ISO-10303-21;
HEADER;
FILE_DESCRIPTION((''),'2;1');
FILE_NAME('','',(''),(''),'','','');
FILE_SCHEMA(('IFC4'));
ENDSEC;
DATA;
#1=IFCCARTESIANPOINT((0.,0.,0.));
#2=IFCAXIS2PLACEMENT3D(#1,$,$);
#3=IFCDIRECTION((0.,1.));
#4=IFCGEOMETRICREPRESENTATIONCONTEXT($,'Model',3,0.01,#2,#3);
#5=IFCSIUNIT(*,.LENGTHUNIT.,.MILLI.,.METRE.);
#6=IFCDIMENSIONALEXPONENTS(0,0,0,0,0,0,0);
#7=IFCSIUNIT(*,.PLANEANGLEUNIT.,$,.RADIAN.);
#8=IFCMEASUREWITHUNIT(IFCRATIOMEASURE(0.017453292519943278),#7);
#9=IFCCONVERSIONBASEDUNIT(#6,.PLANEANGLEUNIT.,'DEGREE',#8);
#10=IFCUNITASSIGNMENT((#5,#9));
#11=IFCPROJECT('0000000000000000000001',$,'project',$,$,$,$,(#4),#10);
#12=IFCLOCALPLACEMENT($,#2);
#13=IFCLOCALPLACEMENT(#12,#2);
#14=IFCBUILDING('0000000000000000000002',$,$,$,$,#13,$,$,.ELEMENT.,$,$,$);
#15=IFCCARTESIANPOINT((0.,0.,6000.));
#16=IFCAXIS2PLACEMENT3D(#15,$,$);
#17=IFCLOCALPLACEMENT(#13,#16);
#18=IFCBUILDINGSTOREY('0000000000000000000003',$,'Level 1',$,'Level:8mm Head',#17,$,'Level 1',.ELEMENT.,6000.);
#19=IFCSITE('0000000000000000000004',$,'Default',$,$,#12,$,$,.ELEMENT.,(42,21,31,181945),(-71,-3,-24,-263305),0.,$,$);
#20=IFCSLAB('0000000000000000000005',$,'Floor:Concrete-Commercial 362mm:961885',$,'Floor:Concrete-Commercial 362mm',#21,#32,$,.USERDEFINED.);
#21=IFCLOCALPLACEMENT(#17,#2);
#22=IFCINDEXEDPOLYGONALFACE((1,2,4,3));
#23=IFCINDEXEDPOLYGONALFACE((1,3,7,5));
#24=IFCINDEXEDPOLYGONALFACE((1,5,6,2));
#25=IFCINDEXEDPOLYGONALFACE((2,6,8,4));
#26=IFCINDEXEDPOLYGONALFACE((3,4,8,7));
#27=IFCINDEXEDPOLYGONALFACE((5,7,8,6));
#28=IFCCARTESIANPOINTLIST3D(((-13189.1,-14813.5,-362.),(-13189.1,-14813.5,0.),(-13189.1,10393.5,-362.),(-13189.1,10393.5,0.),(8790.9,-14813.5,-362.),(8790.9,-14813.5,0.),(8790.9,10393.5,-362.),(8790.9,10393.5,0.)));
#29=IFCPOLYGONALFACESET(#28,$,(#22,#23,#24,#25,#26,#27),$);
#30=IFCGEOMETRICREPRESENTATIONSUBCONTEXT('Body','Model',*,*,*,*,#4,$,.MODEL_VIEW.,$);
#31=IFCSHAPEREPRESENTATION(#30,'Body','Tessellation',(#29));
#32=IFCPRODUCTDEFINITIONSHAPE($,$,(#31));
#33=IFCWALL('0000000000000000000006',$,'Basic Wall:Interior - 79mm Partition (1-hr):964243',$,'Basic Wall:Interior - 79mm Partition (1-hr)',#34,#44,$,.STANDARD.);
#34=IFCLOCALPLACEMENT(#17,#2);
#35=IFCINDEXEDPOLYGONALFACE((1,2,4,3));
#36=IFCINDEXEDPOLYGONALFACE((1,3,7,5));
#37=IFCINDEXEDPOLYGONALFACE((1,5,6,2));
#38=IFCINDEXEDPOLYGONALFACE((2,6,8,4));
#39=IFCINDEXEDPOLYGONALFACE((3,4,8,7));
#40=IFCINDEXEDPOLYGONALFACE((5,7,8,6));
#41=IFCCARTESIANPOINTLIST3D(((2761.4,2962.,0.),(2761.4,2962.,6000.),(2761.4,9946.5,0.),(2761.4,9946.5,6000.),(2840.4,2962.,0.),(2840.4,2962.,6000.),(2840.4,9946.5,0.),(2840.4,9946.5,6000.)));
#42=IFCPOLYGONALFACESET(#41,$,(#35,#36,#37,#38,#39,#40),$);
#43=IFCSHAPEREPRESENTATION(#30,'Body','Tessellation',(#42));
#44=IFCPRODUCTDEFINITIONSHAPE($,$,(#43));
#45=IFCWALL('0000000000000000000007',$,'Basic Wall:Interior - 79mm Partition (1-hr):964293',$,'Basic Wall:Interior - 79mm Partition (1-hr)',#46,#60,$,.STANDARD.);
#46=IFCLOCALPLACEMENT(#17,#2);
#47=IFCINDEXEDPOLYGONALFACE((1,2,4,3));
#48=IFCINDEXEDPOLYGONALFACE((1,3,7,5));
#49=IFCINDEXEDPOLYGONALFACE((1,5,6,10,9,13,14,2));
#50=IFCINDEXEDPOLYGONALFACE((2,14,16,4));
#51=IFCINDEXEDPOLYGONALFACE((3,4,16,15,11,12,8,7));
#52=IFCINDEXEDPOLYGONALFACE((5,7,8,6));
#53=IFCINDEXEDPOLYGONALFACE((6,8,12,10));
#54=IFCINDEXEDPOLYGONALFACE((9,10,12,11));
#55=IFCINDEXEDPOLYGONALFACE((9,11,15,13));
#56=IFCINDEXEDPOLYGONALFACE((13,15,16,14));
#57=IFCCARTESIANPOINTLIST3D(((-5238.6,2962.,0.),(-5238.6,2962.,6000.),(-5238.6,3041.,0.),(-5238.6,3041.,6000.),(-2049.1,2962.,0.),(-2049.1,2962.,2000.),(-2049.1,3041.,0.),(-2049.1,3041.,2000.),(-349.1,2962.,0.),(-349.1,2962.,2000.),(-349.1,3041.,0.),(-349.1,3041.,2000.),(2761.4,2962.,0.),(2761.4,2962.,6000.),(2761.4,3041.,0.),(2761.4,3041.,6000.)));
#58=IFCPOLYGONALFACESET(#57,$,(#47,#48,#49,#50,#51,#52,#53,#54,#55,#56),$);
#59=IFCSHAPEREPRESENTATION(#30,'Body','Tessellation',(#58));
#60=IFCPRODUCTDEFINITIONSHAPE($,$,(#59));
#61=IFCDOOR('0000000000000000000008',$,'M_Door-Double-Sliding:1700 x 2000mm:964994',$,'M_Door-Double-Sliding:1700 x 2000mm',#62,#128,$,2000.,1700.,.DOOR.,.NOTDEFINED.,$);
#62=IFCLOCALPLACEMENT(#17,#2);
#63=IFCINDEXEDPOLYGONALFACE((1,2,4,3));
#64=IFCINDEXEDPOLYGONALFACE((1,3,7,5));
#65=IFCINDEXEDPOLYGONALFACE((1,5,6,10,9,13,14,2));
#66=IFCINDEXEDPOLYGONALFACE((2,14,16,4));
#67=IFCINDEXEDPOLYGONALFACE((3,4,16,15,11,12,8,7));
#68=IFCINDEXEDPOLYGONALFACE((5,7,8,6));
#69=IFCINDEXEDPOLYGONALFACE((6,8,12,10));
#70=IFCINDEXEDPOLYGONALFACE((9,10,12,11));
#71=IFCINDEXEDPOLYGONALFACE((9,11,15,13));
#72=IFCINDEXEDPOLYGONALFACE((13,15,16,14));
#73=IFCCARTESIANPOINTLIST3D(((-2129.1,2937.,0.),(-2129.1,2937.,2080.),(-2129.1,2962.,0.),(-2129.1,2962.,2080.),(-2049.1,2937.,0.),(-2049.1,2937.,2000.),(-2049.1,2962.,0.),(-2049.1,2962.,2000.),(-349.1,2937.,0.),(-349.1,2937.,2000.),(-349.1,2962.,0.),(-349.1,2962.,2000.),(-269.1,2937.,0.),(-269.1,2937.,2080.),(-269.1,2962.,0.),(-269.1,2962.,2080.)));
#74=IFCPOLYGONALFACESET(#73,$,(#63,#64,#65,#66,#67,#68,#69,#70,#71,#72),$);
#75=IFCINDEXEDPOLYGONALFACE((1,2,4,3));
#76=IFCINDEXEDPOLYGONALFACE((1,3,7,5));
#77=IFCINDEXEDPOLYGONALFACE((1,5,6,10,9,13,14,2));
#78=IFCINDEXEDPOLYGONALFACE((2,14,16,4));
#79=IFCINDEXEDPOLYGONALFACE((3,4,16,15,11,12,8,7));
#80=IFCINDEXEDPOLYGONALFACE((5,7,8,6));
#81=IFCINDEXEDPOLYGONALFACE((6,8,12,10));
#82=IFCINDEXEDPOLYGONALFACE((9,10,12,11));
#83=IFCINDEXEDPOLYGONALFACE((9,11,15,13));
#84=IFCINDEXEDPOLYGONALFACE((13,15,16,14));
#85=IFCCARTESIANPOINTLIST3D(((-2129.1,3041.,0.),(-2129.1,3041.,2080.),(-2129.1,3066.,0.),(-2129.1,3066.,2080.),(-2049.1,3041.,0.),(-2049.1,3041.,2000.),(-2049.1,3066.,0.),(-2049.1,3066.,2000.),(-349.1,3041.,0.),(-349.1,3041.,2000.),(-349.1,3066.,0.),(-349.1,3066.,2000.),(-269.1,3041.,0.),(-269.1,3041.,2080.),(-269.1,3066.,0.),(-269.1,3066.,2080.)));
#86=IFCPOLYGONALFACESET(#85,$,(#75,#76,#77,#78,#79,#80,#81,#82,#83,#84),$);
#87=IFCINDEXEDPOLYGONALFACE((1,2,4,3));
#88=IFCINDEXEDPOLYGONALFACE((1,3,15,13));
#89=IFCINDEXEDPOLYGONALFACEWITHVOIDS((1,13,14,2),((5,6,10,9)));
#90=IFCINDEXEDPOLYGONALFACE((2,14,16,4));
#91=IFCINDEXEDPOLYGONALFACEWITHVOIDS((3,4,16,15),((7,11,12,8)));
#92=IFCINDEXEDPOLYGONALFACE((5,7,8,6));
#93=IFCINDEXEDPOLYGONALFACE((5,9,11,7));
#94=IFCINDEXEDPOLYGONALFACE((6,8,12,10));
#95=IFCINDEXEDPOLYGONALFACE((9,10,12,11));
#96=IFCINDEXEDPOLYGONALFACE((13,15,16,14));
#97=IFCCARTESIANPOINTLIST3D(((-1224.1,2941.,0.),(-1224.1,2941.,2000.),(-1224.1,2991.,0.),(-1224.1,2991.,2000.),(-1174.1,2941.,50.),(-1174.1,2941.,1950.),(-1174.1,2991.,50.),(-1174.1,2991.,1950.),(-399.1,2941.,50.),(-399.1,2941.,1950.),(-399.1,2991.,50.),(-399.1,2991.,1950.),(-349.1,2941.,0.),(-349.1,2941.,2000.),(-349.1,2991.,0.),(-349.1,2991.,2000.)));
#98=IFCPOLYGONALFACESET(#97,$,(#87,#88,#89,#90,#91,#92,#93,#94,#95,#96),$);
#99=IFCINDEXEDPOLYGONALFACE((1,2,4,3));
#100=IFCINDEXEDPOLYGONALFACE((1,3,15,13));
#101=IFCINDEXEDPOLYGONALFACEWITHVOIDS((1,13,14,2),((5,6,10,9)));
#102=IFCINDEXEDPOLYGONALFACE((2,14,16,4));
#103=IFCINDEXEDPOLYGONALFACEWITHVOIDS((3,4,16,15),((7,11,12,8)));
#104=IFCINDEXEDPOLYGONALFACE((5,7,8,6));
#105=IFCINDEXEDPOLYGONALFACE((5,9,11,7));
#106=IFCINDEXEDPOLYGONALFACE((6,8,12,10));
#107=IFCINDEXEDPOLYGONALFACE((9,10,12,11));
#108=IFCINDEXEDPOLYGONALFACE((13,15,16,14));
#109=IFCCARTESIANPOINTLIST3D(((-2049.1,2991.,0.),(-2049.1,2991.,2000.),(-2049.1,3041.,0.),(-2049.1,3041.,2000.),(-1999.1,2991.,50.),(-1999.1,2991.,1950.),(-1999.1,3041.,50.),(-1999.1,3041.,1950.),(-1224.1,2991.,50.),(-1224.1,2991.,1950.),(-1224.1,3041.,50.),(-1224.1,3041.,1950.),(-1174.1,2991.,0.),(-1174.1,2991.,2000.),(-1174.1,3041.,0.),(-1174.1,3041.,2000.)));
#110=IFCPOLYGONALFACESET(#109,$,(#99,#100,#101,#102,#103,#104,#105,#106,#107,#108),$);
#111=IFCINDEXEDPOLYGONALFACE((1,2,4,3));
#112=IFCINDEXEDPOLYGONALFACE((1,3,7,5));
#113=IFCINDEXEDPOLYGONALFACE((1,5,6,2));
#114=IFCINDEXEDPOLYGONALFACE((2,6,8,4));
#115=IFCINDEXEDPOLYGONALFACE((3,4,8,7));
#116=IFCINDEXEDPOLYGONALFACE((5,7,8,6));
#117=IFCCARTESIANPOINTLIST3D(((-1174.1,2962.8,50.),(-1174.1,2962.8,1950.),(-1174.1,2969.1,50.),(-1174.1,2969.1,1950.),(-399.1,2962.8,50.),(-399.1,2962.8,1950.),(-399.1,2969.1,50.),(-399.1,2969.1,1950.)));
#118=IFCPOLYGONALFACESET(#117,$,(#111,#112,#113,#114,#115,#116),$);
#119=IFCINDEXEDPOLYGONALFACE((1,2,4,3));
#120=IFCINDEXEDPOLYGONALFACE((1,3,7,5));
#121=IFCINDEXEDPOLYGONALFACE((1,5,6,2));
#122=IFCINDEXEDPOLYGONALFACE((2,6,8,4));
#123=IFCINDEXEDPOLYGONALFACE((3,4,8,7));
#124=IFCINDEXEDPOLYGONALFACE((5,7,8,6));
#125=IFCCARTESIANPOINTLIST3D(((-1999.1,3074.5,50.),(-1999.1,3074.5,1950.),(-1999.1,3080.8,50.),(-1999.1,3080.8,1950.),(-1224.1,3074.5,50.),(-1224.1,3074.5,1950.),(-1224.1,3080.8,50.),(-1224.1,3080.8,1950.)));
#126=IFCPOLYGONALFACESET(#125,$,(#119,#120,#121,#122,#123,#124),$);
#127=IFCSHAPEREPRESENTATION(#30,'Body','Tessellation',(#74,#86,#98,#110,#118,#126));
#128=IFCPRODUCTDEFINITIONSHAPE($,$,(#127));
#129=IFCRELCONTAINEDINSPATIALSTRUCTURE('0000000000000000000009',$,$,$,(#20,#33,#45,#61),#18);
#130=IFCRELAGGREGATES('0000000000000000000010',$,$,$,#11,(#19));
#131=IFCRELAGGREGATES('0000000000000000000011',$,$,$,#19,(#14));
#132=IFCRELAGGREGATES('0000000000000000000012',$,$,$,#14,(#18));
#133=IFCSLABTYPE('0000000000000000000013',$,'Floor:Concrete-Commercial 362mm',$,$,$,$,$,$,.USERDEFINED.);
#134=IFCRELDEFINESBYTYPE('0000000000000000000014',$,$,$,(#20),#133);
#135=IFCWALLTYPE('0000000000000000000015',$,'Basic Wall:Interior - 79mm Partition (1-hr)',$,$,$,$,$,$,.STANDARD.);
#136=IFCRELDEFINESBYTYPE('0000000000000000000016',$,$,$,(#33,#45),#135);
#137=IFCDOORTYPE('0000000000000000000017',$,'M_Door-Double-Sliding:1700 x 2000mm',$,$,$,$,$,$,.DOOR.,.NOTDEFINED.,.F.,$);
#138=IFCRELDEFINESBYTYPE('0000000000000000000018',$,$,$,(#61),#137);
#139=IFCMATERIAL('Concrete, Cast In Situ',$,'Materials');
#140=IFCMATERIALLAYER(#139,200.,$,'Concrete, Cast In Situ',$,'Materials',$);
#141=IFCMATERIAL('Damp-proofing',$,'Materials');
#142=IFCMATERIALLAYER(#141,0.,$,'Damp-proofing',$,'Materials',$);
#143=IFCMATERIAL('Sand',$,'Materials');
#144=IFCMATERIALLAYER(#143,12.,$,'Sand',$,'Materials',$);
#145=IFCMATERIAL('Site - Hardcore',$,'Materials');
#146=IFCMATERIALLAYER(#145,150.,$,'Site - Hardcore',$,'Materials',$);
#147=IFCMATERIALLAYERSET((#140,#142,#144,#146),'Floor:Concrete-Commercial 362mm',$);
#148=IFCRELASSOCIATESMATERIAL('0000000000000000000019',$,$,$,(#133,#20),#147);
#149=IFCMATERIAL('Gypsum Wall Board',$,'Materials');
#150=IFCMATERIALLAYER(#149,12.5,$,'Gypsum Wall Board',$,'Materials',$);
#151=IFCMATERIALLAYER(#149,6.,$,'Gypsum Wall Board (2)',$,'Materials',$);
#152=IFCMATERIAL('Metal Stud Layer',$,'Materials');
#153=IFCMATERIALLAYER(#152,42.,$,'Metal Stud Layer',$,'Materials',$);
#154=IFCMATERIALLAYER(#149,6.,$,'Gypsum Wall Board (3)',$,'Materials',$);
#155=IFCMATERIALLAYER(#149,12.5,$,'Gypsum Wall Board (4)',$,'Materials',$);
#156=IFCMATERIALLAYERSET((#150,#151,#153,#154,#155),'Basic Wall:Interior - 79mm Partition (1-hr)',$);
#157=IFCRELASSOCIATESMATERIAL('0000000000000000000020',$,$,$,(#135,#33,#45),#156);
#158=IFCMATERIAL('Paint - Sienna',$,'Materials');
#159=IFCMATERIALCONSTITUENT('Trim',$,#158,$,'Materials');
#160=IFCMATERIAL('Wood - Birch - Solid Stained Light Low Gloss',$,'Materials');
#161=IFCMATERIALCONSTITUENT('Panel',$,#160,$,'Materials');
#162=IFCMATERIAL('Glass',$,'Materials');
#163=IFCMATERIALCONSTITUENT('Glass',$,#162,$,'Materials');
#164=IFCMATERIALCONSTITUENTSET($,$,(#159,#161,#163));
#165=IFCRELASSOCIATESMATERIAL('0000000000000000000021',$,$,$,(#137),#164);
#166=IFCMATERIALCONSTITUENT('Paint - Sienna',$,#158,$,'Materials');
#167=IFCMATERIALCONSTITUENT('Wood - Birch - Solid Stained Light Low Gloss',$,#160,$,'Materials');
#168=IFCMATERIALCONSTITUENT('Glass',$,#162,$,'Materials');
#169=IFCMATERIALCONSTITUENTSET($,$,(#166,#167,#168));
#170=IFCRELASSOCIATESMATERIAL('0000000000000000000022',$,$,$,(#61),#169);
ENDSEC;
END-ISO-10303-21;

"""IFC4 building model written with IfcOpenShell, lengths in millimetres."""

from ifc_helpers import new_model, entity, si_unit, converted_unit, direction, frame, frame_2d, origin, origin_2d_with_axis, place, context, subcontext, project, spatial, polyline, rectangle, outline, extrude, source, transform, mapped, material, layer, layer_set, layer_usage, constituent, constituent_set, type_object, type_shapes, element, fill, save


model = new_model("IFC4")

# Units and contexts
model_context = context("Model", 3, precision=0.01, world=origin(), true_north=direction((0.0, 1.0)))
body_context = subcontext(model_context, "Body", "Model", "MODEL_VIEW")
ifc_project = project(units=[si_unit("LENGTHUNIT", "METRE", prefix="MILLI"), converted_unit("PLANEANGLEUNIT", "DEGREE", entity("IfcRatioMeasure", 0.017453292519943278), si_unit("PLANEANGLEUNIT", "RADIAN"), dimensions=[0, 0, 0, 0, 0, 0, 0])], contexts=[model_context])

# Site, building, storey
site_placement = place(None, origin())
site = spatial("IfcSite", under=ifc_project, at=site_placement, Name="Default", CompositionType="ELEMENT", RefLatitude=(42, 21, 31, 181945), RefLongitude=(-71, -3, -24, -263305), RefElevation=0.0)
building_placement = place(site_placement, origin())
building = spatial("IfcBuilding", under=site, at=building_placement, CompositionType="ELEMENT")
storey_placement = place(building_placement, frame((0.0, 0.0, 6000.0)))
storey = spatial("IfcBuildingStorey", under=building, at=storey_placement, Name="Level 1", ObjectType="Level:8mm Head", LongName="Level 1", CompositionType="ELEMENT", Elevation=6000.0)

# Slab
ifc_material_1 = material(Name="Concrete, Cast In Situ", Category="Materials")
ifc_layer_1 = layer(ifc_material_1, 200.0, Name="Concrete, Cast In Situ", Category="Materials")
ifc_material_2 = material(Name="Damp-proofing", Category="Materials")
ifc_layer_2 = layer(ifc_material_2, 0.0, Name="Damp-proofing", Category="Materials")
ifc_material_3 = material(Name="Sand", Category="Materials")
ifc_layer_3 = layer(ifc_material_3, 12.0, Name="Sand", Category="Materials")
ifc_material_4 = material(Name="Site - Hardcore", Category="Materials")
ifc_layer_4 = layer(ifc_material_4, 150.0, Name="Site - Hardcore", Category="Materials")
ifc_layer_set_1 = layer_set([ifc_layer_1, ifc_layer_2, ifc_layer_3, ifc_layer_4], Name="Floor:Concrete-Commercial 362mm")
ifc_layer_usage_1 = layer_usage(ifc_layer_set_1, "AXIS3", "POSITIVE", 0.0)
slab_type = type_object("IfcSlabType", Name="Floor:Concrete-Commercial 362mm", PredefinedType="USERDEFINED", material=ifc_layer_set_1)
slab_placement = place(storey_placement, origin())
element("IfcSlab", 1, at=slab_placement, inside=storey, type_object=slab_type, material=ifc_layer_usage_1, Name="Floor:Concrete-Commercial 362mm:961885", ObjectType="Floor:Concrete-Commercial 362mm", PredefinedType="USERDEFINED", context=body_context, shape_type="SweptSolid", body=[
    extrude(rectangle(XDim=25207.0, YDim=21980.0, at=frame_2d((0.0, 0.0), x_axis=(1.0, 0.0))), frame((-2199.1, -2210.0, 0.0), z_axis=(0.0, 0.0, -1.0), x_axis=(0.0, 1.0, 0.0)), (0.0, 0.0, 1.0), 362.0),
])

# Wall
ifc_material_5 = material(Name="Gypsum Wall Board", Category="Materials")
ifc_layer_5 = layer(ifc_material_5, 12.5, Name="Gypsum Wall Board", Category="Materials")
ifc_layer_6 = layer(ifc_material_5, 6.0, Name="Gypsum Wall Board (2)", Category="Materials")
ifc_material_6 = material(Name="Metal Stud Layer", Category="Materials")
ifc_layer_7 = layer(ifc_material_6, 42.0, Name="Metal Stud Layer", Category="Materials")
ifc_layer_8 = layer(ifc_material_5, 6.0, Name="Gypsum Wall Board (3)", Category="Materials")
ifc_layer_9 = layer(ifc_material_5, 12.5, Name="Gypsum Wall Board (4)", Category="Materials")
ifc_layer_set_2 = layer_set([ifc_layer_5, ifc_layer_6, ifc_layer_7, ifc_layer_8, ifc_layer_9], Name="Basic Wall:Interior - 79mm Partition (1-hr)")
ifc_layer_usage_2 = layer_usage(ifc_layer_set_2, "AXIS2", "NEGATIVE", 39.5)
wall_type = type_object("IfcWallType", Name="Basic Wall:Interior - 79mm Partition (1-hr)", PredefinedType="STANDARD", material=ifc_layer_set_2)
wall_1_placement = place(storey_placement, frame((2800.9, 9946.5, 0.0), z_axis=(0.0, 0.0, 1.0), x_axis=(0.0, -1.0, 0.0)))
element("IfcWall", 2, at=wall_1_placement, inside=storey, type_object=wall_type, material=ifc_layer_usage_2, Name="Basic Wall:Interior - 79mm Partition (1-hr):964243", ObjectType="Basic Wall:Interior - 79mm Partition (1-hr)", PredefinedType="STANDARD", context=body_context, shape_type="SweptSolid", body=[
    extrude(rectangle(XDim=6984.5, YDim=79.0, at=frame_2d((3492.3, 0.0), x_axis=(-1.0, 0.0))), origin(), (0.0, 0.0, 1.0), 6000.0),
])

# Wall, opening, door
wall_2_placement = place(storey_placement, frame((2761.4, 3001.5, 0.0), z_axis=(0.0, 0.0, 1.0), x_axis=(-1.0, 0.0, 0.0)))
wall_2 = element("IfcWall", 3, at=wall_2_placement, inside=storey, type_object=wall_type, material=ifc_layer_usage_2, Name="Basic Wall:Interior - 79mm Partition (1-hr):964293", ObjectType="Basic Wall:Interior - 79mm Partition (1-hr)", PredefinedType="STANDARD", context=body_context, shape_type="SweptSolid", body=[
    extrude(rectangle(XDim=8000.0, YDim=79.0, at=frame_2d((4000.0, 0.0), x_axis=(-1.0, 0.0))), origin(), (0.0, 0.0, 1.0), 6000.0),
])
opening_1_placement = place(wall_2_placement, frame((4810.5, 39.5, 0.0)))
opening_1 = element("IfcOpeningElement", 4, at=opening_1_placement, cuts=wall_2, PredefinedType="OPENING", context=body_context, shape_type="SweptSolid", body=[
    extrude(rectangle(XDim=2000.0, YDim=1700.0, at=frame_2d((1000.0, 850.0), x_axis=(-1.0, 0.0))), frame((0.0, 0.0, 0.0), z_axis=(0.0, -1.0, 0.0), x_axis=(0.0, 0.0, 1.0)), (0.0, 0.0, 1.0), 79.0),
])
ifc_material_7 = material(Name="Paint - Sienna", Category="Materials")
ifc_constituent_1 = constituent(ifc_material_7, Name="Paint - Sienna", Category="Materials")
ifc_material_8 = material(Name="Wood - Birch - Solid Stained Light Low Gloss", Category="Materials")
ifc_constituent_2 = constituent(ifc_material_8, Name="Wood - Birch - Solid Stained Light Low Gloss", Category="Materials")
ifc_material_9 = material(Name="Glass", Category="Materials")
ifc_constituent_3 = constituent(ifc_material_9, Name="Glass", Category="Materials")
ifc_constituent_set_1 = constituent_set(constituents=[ifc_constituent_1, ifc_constituent_2, ifc_constituent_3])
ifc_constituent_4 = constituent(ifc_material_7, Name="Trim", Category="Materials")
ifc_constituent_5 = constituent(ifc_material_8, Name="Panel", Category="Materials")
ifc_constituent_6 = constituent(ifc_material_9, Name="Glass", Category="Materials")
ifc_constituent_set_2 = constituent_set(constituents=[ifc_constituent_4, ifc_constituent_5, ifc_constituent_6])
door_type = type_object("IfcDoorType", Name="M_Door-Double-Sliding:1700 x 2000mm", OperationType="NOTDEFINED", ParameterTakesPrecedence=False, PredefinedType="DOOR", material=ifc_constituent_set_2)
shared_shape_1 = source(origin(), body_context, "Body", "SweptSolid", [
    extrude(outline(polyline([(-1020.0, -930.0), (1060.0, -930.0), (1060.0, 930.0), (-1020.0, 930.0), (-1020.0, 850.0), (980.0, 850.0), (980.0, -850.0), (-1020.0, -850.0), (-1020.0, -930.0)])), frame((850.0, -25.0, 1020.0), z_axis=(0.0, 1.0, 0.0), x_axis=(0.0, 0.0, 1.0)), (0.0, 0.0, 1.0), 25.0),
    extrude(outline(polyline([(-930.0, -1020.0), (-850.0, -1020.0), (-850.0, 980.0), (850.0, 980.0), (850.0, -1020.0), (930.0, -1020.0), (930.0, 1060.0), (-930.0, 1060.0), (-930.0, -1020.0)])), frame((850.0, 79.0, 1020.0), z_axis=(0.0, 1.0, 0.0), x_axis=(-1.0, 0.0, 0.0)), (0.0, 0.0, 1.0), 25.0),
    extrude(outline(polyline([(-437.5, -1000.0), (437.5, -1000.0), (437.5, 1000.0), (-437.5, 1000.0), (-437.5, -1000.0)]), holes=[polyline([(-387.5, -950.0), (-387.5, 950.0), (387.5, 950.0), (387.5, -950.0), (-387.5, -950.0)])]), frame((1262.5, -21.0, 1000.0), z_axis=(0.0, 1.0, 0.0), x_axis=(1.0, 0.0, 0.0)), (0.0, 0.0, 1.0), 50.0),
    extrude(outline(polyline([(-1000.0, -437.5), (1000.0, -437.5), (1000.0, 437.5), (-1000.0, 437.5), (-1000.0, -437.5)]), holes=[polyline([(-950.0, -387.5), (-950.0, 387.5), (950.0, 387.5), (950.0, -387.5), (-950.0, -387.5)])]), frame((437.5, 29.0, 1000.0), z_axis=(0.0, 1.0, 0.0), x_axis=(0.0, 0.0, -1.0)), (0.0, 0.0, 1.0), 50.0),
    extrude(rectangle(XDim=6.3, YDim=775.0, at=frame_2d((0.0, 0.0), x_axis=(1.0, 0.0))), frame((1262.5, 4.0, 50.0), z_axis=(0.0, 0.0, 1.0), x_axis=(0.0, -1.0, 0.0)), (0.0, 0.0, 1.0), 1900.0),
    extrude(rectangle(XDim=6.4, YDim=775.0, at=origin_2d_with_axis()), frame((437.5, 115.7, 50.0), z_axis=(0.0, 0.0, 1.0), x_axis=(0.0, 1.0, 0.0)), (0.0, 0.0, 1.0), 1900.0),
])
type_shapes(door_type, [shared_shape_1])
door_1_placement = place(opening_1_placement, frame((0.0, 0.0, 0.0), z_axis=(0.0, 0.0, 1.0), x_axis=(-1.0, 0.0, 0.0)))
door_1 = element("IfcDoor", 5, at=door_1_placement, inside=storey, type_object=door_type, material=ifc_constituent_set_1, Name="M_Door-Double-Sliding:1700 x 2000mm:964994", ObjectType="M_Door-Double-Sliding:1700 x 2000mm", OperationType="NOTDEFINED", OverallHeight=2000.0, OverallWidth=1700.0, PredefinedType="DOOR", context=body_context, shape_type="MappedRepresentation", body=[
    mapped(shared_shape_1, transform((0.0, 0.0, 0.0), scale=1.0)),
])
fill(opening_1, door_1)

save(model, "model.ifc")
